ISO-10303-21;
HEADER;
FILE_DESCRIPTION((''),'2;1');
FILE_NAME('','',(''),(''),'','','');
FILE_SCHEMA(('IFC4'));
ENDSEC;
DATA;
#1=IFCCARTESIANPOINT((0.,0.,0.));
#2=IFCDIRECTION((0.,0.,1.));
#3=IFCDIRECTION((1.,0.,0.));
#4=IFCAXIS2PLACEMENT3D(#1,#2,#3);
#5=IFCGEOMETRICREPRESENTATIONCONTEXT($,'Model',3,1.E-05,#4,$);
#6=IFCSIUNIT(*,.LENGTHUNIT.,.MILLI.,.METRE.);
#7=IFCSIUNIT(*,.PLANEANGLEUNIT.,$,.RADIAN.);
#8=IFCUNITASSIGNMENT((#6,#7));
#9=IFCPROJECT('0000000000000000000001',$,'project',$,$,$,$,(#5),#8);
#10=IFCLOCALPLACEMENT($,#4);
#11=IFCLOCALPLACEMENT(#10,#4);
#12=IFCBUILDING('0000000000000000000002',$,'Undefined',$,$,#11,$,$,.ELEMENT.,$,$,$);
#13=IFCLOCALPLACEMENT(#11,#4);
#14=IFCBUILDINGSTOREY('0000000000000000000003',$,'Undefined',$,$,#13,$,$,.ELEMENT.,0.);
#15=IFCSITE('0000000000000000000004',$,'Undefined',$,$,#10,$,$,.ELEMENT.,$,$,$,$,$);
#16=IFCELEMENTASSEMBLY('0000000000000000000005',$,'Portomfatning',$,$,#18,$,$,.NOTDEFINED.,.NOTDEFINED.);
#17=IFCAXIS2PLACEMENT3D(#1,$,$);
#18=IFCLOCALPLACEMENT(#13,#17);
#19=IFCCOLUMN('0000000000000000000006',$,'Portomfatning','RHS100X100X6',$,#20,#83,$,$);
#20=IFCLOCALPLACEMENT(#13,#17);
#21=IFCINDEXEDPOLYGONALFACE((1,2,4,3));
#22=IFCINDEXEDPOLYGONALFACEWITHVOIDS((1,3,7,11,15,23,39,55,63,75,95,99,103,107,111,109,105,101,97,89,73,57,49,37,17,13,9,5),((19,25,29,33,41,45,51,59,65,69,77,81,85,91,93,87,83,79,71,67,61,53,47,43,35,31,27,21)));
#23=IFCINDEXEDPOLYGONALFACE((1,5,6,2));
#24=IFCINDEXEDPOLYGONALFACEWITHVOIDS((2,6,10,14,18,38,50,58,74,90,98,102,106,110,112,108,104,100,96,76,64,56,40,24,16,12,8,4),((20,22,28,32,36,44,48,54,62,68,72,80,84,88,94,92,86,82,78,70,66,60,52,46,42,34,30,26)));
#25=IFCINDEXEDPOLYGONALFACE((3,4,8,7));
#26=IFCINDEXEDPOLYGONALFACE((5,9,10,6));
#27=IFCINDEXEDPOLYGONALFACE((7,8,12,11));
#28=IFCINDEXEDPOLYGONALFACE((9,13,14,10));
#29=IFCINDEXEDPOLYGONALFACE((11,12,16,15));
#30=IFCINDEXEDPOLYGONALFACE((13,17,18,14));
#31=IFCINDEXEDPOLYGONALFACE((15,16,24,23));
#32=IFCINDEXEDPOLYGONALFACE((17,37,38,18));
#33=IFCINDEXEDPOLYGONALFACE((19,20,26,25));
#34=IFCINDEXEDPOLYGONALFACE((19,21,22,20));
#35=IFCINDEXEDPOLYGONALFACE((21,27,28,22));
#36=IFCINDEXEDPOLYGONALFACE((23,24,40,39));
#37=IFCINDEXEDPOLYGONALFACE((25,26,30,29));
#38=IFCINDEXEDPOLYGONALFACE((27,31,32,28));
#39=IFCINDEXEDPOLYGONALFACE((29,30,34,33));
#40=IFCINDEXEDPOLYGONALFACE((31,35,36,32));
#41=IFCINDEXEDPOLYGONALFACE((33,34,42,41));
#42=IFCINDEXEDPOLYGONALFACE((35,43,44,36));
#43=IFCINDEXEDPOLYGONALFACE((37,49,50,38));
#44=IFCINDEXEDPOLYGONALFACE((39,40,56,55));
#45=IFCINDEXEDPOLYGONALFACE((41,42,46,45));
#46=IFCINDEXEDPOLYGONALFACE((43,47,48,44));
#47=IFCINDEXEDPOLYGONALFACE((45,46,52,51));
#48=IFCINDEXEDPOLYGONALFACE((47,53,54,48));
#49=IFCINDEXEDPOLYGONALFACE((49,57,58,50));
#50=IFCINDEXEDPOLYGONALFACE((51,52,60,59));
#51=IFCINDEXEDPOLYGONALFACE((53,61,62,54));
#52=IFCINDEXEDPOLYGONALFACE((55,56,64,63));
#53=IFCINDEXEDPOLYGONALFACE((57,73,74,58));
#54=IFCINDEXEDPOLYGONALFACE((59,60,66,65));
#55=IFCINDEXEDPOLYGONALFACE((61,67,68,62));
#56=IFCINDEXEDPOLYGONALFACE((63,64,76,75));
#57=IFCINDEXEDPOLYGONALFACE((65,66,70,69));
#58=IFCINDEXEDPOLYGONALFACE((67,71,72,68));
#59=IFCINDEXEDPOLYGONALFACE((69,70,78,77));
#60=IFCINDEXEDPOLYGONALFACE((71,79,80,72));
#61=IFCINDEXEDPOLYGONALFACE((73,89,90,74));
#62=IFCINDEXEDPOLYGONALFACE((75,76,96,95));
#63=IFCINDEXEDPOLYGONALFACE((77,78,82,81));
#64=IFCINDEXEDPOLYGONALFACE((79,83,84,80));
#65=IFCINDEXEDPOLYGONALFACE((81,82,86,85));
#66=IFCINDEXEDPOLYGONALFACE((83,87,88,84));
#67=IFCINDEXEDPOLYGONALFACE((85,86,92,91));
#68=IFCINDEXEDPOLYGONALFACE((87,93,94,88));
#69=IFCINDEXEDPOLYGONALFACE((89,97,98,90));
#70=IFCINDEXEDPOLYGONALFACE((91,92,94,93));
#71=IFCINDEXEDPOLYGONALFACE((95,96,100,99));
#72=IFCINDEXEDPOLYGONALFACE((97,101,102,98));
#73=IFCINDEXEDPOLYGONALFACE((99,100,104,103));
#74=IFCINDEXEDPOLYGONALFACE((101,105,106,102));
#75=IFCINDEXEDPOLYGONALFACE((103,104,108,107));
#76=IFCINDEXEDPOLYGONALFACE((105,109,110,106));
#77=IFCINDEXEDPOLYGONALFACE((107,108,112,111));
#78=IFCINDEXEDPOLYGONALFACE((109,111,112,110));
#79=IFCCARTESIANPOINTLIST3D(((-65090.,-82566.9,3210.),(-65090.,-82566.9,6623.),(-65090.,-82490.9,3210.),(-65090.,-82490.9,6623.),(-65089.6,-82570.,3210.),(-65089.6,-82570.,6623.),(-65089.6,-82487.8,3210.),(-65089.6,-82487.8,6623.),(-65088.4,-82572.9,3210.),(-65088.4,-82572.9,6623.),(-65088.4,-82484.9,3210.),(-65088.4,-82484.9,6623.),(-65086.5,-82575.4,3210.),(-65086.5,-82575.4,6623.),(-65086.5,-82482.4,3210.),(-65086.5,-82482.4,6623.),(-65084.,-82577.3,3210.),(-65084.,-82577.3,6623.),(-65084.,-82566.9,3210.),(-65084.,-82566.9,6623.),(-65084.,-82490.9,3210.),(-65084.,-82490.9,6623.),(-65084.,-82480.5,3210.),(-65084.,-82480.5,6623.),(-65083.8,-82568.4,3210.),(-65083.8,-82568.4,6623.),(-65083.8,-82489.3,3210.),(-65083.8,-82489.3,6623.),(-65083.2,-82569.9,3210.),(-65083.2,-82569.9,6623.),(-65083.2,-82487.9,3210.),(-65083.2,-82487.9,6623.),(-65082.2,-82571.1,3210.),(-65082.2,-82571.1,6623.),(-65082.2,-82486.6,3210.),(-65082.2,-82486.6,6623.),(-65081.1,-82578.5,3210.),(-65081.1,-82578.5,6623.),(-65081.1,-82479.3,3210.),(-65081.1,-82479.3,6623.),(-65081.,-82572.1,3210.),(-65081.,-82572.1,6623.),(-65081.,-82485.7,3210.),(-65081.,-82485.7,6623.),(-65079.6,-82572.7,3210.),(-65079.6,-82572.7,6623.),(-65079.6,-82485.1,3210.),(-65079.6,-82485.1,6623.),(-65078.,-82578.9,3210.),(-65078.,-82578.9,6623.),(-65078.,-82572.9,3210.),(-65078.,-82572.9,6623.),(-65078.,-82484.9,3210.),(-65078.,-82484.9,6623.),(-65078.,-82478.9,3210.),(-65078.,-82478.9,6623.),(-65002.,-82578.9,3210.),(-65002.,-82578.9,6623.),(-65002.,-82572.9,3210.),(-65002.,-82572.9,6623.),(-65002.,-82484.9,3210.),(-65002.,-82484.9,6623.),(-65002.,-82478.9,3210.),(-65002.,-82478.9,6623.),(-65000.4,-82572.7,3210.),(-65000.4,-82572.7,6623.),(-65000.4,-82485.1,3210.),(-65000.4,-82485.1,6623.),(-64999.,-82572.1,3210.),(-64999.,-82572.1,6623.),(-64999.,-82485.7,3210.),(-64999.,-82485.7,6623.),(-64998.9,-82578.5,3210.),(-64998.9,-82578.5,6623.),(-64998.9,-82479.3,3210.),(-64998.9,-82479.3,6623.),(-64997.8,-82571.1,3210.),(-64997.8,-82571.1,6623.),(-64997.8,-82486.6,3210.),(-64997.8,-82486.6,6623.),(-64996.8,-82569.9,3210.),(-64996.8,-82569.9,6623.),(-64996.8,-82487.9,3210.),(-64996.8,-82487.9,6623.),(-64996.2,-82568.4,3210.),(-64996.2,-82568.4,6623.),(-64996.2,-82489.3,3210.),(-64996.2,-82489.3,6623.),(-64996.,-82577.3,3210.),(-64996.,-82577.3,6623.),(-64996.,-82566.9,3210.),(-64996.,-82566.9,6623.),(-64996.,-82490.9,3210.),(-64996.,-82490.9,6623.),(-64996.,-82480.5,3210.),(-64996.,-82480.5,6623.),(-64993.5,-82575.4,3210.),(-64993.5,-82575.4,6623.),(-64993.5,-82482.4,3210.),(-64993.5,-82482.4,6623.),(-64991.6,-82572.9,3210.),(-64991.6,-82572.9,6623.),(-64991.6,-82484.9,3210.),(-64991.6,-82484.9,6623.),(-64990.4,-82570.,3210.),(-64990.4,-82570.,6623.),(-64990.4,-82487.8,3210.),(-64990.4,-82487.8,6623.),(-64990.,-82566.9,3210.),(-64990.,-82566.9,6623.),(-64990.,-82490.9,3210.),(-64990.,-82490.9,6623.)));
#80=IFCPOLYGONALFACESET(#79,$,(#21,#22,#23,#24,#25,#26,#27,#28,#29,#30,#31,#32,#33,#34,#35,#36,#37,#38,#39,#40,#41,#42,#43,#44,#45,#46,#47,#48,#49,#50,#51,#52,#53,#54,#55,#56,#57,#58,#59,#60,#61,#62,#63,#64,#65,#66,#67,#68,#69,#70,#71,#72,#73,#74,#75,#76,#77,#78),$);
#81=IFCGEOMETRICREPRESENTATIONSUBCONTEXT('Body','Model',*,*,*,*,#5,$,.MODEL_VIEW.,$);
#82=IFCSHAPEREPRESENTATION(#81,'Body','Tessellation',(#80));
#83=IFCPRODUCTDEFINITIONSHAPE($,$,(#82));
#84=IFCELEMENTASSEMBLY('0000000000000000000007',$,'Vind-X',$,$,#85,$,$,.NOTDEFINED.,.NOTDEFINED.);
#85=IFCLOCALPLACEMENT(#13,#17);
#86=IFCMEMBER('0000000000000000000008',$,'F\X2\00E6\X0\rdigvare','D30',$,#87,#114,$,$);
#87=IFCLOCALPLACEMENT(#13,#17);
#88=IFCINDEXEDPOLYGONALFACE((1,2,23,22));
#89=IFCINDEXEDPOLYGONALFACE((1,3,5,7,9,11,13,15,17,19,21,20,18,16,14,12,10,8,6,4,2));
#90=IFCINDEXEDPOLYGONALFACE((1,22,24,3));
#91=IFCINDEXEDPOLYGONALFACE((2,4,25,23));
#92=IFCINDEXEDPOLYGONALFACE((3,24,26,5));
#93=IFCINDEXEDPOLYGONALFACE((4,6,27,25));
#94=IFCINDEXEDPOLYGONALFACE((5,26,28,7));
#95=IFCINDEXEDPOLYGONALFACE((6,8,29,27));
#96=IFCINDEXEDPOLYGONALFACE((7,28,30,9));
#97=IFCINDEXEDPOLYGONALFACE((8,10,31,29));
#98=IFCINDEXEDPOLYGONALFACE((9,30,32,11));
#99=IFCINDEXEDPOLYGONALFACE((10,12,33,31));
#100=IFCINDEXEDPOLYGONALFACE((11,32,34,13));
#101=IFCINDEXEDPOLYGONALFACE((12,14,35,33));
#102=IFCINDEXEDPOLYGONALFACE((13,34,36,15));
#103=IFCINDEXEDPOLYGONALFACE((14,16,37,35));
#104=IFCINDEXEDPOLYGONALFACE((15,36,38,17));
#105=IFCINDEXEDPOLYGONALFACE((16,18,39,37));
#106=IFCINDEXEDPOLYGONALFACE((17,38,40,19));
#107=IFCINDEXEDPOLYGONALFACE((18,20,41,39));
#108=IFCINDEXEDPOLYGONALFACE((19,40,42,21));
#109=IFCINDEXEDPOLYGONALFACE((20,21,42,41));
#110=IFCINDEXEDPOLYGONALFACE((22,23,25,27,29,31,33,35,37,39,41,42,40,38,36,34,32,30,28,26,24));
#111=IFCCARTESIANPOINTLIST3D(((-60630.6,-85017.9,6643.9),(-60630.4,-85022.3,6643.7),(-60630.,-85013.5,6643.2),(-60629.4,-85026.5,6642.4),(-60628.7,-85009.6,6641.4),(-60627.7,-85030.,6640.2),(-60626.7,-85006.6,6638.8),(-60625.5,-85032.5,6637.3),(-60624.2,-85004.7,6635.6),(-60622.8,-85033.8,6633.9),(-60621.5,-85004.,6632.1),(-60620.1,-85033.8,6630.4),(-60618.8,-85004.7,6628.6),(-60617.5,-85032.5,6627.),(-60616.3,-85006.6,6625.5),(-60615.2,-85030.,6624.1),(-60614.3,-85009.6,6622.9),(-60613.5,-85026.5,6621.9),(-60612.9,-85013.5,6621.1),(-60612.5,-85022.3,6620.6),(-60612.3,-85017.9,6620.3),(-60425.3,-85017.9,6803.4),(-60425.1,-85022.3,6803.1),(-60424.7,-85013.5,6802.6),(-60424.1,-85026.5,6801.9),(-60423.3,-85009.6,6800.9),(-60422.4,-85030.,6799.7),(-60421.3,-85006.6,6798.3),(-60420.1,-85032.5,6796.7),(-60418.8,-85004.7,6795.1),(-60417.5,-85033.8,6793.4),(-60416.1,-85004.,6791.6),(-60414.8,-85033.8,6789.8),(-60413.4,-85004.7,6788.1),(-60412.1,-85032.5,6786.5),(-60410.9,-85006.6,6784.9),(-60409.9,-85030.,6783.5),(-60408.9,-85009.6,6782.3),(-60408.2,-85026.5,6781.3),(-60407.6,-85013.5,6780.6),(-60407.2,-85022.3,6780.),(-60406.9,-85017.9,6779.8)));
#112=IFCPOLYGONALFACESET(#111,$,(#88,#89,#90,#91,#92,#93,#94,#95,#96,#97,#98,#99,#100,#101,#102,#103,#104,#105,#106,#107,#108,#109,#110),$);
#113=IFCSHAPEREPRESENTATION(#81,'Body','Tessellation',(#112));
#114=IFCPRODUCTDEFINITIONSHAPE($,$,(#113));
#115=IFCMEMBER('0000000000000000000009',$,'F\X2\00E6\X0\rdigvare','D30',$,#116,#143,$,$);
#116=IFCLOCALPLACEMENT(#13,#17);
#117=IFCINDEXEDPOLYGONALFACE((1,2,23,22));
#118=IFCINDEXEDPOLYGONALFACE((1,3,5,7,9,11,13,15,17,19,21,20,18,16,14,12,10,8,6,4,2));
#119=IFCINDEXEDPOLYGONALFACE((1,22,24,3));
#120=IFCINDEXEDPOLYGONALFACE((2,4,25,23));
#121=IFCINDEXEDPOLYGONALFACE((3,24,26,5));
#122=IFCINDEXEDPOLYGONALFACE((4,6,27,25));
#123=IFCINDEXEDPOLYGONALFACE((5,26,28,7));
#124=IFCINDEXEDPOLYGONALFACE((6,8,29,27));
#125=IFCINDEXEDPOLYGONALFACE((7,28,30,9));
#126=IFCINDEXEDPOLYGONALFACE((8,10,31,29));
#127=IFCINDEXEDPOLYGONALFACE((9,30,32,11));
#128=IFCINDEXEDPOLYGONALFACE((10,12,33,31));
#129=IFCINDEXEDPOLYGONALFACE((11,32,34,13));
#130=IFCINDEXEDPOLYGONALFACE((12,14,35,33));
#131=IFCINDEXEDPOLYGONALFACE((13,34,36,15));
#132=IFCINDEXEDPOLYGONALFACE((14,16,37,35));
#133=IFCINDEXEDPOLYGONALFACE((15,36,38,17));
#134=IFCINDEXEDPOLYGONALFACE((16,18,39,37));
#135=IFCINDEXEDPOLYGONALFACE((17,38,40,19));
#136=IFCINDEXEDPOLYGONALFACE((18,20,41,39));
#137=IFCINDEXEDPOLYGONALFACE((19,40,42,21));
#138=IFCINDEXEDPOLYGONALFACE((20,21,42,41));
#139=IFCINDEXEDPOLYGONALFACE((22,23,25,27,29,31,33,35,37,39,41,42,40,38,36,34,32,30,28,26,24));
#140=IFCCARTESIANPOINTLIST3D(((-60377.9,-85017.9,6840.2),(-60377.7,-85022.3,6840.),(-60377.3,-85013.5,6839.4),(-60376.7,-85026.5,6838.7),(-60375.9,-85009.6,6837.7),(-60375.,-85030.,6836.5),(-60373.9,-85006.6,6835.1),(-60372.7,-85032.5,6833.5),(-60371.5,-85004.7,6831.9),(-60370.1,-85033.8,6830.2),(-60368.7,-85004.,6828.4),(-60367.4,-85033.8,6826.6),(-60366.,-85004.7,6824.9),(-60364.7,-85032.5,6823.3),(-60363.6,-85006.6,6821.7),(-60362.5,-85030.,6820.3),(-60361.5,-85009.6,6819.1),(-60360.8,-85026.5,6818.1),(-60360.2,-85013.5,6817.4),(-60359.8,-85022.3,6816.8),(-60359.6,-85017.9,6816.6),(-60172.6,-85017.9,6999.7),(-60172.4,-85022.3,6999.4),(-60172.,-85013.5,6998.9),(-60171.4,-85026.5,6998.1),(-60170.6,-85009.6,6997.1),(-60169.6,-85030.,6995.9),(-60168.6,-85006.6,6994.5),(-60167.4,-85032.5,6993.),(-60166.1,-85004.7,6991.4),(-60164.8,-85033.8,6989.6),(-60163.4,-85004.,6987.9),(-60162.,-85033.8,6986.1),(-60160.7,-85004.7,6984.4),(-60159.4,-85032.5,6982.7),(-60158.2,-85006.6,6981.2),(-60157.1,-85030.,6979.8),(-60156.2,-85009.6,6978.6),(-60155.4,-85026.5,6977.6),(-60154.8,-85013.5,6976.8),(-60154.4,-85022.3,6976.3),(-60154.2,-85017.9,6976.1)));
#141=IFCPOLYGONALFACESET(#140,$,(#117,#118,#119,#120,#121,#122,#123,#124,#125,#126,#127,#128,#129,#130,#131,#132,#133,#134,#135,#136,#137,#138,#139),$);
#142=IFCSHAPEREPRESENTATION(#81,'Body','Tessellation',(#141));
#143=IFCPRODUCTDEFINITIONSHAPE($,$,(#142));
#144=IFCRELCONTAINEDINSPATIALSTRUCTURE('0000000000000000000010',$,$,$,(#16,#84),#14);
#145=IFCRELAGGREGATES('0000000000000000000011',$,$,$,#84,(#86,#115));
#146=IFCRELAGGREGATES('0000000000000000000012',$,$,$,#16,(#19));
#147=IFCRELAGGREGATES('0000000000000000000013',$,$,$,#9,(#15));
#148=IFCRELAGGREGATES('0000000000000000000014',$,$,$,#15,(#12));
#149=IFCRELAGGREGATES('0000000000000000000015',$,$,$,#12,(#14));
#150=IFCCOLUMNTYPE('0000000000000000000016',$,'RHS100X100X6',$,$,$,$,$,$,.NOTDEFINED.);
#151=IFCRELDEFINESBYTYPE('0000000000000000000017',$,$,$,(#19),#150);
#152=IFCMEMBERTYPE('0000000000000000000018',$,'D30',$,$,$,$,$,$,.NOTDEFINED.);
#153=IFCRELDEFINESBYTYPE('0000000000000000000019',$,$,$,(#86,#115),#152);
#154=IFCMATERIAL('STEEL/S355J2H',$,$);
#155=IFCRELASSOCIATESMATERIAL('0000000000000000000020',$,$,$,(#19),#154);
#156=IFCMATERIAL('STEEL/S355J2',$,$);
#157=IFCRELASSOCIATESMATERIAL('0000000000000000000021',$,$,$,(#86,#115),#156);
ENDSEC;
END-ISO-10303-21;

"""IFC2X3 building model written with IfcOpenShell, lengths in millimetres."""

from ifc_helpers import new_model, si_unit, frame, origin_with_axes, origin_2d_with_axis, place, context, subcontext, project, spatial, hollow_rectangle, circle, extrude, clip, halfspace, material, type_object, element, aggregate, save


model = new_model("IFC2X3")

# Units and contexts
model_context = context("Model", 3, precision=1e-05, world=origin_with_axes())
body_context = subcontext(model_context, "Body", "Model", "MODEL_VIEW")
ifc_project = project(units=[si_unit("LENGTHUNIT", "METRE", prefix="MILLI"), si_unit("PLANEANGLEUNIT", "RADIAN")], contexts=[model_context])

# Site, building, storey
site_placement = place(None, origin_with_axes())
site = spatial("IfcSite", under=ifc_project, at=site_placement, Name="Undefined", CompositionType="ELEMENT")
building_placement = place(site_placement, origin_with_axes())
building = spatial("IfcBuilding", under=site, at=building_placement, Name="Undefined", CompositionType="ELEMENT")
storey_placement = place(building_placement, origin_with_axes())
storey = spatial("IfcBuildingStorey", under=building, at=storey_placement, Name="Undefined", CompositionType="ELEMENT", Elevation=0.0)

# Element assembly, column
ifc_material_1 = material(Name="STEEL/S355J2H")
column_type = type_object("IfcColumnType", Name="RHS100X100X6", PredefinedType="NOTDEFINED")
assembly_1_placement = place(storey_placement, origin_with_axes())
assembly_1 = element("IfcElementAssembly", 1, at=assembly_1_placement, inside=storey, Name="Portomfatning", AssemblyPlace="NOTDEFINED", PredefinedType="NOTDEFINED")
column_1_placement = place(assembly_1_placement, frame((-65040.0, -82528.9, 3250.0), z_axis=(0.0, 0.0, 1.0), x_axis=(1.0, 0.0, 0.0)))
column_1 = element("IfcColumn", 2, at=column_1_placement, type_object=column_type, material=ifc_material_1, Name="Portomfatning", Description="RHS100X100X6", context=body_context, shape_type="Clipping", body=[
    clip(extrude(hollow_rectangle(XDim=100.0, YDim=100.0, WallThickness=6.0, InnerFilletRadius=6.0, OuterFilletRadius=12.0, at=origin_2d_with_axis()), frame((0.0, 0.0, 3373.0), z_axis=(0.0, 0.0, -1.0), x_axis=(0.0, 1.0, 0.0)), (0.0, 0.0, 1.0), 3413.0), halfspace(frame((50.0, 0.0, -40.0), z_axis=(0.0, 0.0, 1.0), x_axis=(0.0, -1.0, 0.0)), True)),
])

# Element assembly, members
assembly_2_placement = place(storey_placement, origin_with_axes())
assembly_2 = element("IfcElementAssembly", 3, at=assembly_2_placement, inside=storey, Name="Vind-X", AssemblyPlace="NOTDEFINED", PredefinedType="NOTDEFINED")
ifc_material_2 = material(Name="STEEL/S355J2")
member_type_1 = type_object("IfcMemberType", Name="D30", PredefinedType="NOTDEFINED")
member_1_placement = place(assembly_2_placement, frame((-60416.1, -85019.0, 6791.6), z_axis=(-0.613348, 0.0, 0.789813), x_axis=(-0.789813, 0.0, -0.613348)))
member_1 = element("IfcMember", 4, at=member_1_placement, type_object=member_type_1, material=ifc_material_2, Name="Færdigvare", Description="D30", context=body_context, shape_type="SweptSolid", body=[
    extrude(circle(Radius=15.0, at=origin_2d_with_axis()), frame((260.0, 0.0, 0.0), z_axis=(-1.0, 0.0, 0.0), x_axis=(0.0, -1.0, 0.0)), (0.0, 0.0, 1.0), 260.0),
])
member_2_placement = place(assembly_2_placement, frame((-60163.4, -85019.0, 6987.9), z_axis=(-0.613349, 0.0, 0.789812), x_axis=(-0.789812, 0.0, -0.613349)))
member_2 = element("IfcMember", 5, at=member_2_placement, type_object=member_type_1, material=ifc_material_2, Name="Færdigvare", Description="D30", context=body_context, shape_type="SweptSolid", body=[
    extrude(circle(Radius=15.0, at=origin_2d_with_axis()), frame((260.0, 0.0, 0.0), z_axis=(-1.0, 0.0, 0.0), x_axis=(0.0, -1.0, 0.0)), (0.0, 0.0, 1.0), 260.0),
])

aggregate(assembly_2, [member_1, member_2])
aggregate(assembly_1, [column_1])

save(model, "model.ifc")
